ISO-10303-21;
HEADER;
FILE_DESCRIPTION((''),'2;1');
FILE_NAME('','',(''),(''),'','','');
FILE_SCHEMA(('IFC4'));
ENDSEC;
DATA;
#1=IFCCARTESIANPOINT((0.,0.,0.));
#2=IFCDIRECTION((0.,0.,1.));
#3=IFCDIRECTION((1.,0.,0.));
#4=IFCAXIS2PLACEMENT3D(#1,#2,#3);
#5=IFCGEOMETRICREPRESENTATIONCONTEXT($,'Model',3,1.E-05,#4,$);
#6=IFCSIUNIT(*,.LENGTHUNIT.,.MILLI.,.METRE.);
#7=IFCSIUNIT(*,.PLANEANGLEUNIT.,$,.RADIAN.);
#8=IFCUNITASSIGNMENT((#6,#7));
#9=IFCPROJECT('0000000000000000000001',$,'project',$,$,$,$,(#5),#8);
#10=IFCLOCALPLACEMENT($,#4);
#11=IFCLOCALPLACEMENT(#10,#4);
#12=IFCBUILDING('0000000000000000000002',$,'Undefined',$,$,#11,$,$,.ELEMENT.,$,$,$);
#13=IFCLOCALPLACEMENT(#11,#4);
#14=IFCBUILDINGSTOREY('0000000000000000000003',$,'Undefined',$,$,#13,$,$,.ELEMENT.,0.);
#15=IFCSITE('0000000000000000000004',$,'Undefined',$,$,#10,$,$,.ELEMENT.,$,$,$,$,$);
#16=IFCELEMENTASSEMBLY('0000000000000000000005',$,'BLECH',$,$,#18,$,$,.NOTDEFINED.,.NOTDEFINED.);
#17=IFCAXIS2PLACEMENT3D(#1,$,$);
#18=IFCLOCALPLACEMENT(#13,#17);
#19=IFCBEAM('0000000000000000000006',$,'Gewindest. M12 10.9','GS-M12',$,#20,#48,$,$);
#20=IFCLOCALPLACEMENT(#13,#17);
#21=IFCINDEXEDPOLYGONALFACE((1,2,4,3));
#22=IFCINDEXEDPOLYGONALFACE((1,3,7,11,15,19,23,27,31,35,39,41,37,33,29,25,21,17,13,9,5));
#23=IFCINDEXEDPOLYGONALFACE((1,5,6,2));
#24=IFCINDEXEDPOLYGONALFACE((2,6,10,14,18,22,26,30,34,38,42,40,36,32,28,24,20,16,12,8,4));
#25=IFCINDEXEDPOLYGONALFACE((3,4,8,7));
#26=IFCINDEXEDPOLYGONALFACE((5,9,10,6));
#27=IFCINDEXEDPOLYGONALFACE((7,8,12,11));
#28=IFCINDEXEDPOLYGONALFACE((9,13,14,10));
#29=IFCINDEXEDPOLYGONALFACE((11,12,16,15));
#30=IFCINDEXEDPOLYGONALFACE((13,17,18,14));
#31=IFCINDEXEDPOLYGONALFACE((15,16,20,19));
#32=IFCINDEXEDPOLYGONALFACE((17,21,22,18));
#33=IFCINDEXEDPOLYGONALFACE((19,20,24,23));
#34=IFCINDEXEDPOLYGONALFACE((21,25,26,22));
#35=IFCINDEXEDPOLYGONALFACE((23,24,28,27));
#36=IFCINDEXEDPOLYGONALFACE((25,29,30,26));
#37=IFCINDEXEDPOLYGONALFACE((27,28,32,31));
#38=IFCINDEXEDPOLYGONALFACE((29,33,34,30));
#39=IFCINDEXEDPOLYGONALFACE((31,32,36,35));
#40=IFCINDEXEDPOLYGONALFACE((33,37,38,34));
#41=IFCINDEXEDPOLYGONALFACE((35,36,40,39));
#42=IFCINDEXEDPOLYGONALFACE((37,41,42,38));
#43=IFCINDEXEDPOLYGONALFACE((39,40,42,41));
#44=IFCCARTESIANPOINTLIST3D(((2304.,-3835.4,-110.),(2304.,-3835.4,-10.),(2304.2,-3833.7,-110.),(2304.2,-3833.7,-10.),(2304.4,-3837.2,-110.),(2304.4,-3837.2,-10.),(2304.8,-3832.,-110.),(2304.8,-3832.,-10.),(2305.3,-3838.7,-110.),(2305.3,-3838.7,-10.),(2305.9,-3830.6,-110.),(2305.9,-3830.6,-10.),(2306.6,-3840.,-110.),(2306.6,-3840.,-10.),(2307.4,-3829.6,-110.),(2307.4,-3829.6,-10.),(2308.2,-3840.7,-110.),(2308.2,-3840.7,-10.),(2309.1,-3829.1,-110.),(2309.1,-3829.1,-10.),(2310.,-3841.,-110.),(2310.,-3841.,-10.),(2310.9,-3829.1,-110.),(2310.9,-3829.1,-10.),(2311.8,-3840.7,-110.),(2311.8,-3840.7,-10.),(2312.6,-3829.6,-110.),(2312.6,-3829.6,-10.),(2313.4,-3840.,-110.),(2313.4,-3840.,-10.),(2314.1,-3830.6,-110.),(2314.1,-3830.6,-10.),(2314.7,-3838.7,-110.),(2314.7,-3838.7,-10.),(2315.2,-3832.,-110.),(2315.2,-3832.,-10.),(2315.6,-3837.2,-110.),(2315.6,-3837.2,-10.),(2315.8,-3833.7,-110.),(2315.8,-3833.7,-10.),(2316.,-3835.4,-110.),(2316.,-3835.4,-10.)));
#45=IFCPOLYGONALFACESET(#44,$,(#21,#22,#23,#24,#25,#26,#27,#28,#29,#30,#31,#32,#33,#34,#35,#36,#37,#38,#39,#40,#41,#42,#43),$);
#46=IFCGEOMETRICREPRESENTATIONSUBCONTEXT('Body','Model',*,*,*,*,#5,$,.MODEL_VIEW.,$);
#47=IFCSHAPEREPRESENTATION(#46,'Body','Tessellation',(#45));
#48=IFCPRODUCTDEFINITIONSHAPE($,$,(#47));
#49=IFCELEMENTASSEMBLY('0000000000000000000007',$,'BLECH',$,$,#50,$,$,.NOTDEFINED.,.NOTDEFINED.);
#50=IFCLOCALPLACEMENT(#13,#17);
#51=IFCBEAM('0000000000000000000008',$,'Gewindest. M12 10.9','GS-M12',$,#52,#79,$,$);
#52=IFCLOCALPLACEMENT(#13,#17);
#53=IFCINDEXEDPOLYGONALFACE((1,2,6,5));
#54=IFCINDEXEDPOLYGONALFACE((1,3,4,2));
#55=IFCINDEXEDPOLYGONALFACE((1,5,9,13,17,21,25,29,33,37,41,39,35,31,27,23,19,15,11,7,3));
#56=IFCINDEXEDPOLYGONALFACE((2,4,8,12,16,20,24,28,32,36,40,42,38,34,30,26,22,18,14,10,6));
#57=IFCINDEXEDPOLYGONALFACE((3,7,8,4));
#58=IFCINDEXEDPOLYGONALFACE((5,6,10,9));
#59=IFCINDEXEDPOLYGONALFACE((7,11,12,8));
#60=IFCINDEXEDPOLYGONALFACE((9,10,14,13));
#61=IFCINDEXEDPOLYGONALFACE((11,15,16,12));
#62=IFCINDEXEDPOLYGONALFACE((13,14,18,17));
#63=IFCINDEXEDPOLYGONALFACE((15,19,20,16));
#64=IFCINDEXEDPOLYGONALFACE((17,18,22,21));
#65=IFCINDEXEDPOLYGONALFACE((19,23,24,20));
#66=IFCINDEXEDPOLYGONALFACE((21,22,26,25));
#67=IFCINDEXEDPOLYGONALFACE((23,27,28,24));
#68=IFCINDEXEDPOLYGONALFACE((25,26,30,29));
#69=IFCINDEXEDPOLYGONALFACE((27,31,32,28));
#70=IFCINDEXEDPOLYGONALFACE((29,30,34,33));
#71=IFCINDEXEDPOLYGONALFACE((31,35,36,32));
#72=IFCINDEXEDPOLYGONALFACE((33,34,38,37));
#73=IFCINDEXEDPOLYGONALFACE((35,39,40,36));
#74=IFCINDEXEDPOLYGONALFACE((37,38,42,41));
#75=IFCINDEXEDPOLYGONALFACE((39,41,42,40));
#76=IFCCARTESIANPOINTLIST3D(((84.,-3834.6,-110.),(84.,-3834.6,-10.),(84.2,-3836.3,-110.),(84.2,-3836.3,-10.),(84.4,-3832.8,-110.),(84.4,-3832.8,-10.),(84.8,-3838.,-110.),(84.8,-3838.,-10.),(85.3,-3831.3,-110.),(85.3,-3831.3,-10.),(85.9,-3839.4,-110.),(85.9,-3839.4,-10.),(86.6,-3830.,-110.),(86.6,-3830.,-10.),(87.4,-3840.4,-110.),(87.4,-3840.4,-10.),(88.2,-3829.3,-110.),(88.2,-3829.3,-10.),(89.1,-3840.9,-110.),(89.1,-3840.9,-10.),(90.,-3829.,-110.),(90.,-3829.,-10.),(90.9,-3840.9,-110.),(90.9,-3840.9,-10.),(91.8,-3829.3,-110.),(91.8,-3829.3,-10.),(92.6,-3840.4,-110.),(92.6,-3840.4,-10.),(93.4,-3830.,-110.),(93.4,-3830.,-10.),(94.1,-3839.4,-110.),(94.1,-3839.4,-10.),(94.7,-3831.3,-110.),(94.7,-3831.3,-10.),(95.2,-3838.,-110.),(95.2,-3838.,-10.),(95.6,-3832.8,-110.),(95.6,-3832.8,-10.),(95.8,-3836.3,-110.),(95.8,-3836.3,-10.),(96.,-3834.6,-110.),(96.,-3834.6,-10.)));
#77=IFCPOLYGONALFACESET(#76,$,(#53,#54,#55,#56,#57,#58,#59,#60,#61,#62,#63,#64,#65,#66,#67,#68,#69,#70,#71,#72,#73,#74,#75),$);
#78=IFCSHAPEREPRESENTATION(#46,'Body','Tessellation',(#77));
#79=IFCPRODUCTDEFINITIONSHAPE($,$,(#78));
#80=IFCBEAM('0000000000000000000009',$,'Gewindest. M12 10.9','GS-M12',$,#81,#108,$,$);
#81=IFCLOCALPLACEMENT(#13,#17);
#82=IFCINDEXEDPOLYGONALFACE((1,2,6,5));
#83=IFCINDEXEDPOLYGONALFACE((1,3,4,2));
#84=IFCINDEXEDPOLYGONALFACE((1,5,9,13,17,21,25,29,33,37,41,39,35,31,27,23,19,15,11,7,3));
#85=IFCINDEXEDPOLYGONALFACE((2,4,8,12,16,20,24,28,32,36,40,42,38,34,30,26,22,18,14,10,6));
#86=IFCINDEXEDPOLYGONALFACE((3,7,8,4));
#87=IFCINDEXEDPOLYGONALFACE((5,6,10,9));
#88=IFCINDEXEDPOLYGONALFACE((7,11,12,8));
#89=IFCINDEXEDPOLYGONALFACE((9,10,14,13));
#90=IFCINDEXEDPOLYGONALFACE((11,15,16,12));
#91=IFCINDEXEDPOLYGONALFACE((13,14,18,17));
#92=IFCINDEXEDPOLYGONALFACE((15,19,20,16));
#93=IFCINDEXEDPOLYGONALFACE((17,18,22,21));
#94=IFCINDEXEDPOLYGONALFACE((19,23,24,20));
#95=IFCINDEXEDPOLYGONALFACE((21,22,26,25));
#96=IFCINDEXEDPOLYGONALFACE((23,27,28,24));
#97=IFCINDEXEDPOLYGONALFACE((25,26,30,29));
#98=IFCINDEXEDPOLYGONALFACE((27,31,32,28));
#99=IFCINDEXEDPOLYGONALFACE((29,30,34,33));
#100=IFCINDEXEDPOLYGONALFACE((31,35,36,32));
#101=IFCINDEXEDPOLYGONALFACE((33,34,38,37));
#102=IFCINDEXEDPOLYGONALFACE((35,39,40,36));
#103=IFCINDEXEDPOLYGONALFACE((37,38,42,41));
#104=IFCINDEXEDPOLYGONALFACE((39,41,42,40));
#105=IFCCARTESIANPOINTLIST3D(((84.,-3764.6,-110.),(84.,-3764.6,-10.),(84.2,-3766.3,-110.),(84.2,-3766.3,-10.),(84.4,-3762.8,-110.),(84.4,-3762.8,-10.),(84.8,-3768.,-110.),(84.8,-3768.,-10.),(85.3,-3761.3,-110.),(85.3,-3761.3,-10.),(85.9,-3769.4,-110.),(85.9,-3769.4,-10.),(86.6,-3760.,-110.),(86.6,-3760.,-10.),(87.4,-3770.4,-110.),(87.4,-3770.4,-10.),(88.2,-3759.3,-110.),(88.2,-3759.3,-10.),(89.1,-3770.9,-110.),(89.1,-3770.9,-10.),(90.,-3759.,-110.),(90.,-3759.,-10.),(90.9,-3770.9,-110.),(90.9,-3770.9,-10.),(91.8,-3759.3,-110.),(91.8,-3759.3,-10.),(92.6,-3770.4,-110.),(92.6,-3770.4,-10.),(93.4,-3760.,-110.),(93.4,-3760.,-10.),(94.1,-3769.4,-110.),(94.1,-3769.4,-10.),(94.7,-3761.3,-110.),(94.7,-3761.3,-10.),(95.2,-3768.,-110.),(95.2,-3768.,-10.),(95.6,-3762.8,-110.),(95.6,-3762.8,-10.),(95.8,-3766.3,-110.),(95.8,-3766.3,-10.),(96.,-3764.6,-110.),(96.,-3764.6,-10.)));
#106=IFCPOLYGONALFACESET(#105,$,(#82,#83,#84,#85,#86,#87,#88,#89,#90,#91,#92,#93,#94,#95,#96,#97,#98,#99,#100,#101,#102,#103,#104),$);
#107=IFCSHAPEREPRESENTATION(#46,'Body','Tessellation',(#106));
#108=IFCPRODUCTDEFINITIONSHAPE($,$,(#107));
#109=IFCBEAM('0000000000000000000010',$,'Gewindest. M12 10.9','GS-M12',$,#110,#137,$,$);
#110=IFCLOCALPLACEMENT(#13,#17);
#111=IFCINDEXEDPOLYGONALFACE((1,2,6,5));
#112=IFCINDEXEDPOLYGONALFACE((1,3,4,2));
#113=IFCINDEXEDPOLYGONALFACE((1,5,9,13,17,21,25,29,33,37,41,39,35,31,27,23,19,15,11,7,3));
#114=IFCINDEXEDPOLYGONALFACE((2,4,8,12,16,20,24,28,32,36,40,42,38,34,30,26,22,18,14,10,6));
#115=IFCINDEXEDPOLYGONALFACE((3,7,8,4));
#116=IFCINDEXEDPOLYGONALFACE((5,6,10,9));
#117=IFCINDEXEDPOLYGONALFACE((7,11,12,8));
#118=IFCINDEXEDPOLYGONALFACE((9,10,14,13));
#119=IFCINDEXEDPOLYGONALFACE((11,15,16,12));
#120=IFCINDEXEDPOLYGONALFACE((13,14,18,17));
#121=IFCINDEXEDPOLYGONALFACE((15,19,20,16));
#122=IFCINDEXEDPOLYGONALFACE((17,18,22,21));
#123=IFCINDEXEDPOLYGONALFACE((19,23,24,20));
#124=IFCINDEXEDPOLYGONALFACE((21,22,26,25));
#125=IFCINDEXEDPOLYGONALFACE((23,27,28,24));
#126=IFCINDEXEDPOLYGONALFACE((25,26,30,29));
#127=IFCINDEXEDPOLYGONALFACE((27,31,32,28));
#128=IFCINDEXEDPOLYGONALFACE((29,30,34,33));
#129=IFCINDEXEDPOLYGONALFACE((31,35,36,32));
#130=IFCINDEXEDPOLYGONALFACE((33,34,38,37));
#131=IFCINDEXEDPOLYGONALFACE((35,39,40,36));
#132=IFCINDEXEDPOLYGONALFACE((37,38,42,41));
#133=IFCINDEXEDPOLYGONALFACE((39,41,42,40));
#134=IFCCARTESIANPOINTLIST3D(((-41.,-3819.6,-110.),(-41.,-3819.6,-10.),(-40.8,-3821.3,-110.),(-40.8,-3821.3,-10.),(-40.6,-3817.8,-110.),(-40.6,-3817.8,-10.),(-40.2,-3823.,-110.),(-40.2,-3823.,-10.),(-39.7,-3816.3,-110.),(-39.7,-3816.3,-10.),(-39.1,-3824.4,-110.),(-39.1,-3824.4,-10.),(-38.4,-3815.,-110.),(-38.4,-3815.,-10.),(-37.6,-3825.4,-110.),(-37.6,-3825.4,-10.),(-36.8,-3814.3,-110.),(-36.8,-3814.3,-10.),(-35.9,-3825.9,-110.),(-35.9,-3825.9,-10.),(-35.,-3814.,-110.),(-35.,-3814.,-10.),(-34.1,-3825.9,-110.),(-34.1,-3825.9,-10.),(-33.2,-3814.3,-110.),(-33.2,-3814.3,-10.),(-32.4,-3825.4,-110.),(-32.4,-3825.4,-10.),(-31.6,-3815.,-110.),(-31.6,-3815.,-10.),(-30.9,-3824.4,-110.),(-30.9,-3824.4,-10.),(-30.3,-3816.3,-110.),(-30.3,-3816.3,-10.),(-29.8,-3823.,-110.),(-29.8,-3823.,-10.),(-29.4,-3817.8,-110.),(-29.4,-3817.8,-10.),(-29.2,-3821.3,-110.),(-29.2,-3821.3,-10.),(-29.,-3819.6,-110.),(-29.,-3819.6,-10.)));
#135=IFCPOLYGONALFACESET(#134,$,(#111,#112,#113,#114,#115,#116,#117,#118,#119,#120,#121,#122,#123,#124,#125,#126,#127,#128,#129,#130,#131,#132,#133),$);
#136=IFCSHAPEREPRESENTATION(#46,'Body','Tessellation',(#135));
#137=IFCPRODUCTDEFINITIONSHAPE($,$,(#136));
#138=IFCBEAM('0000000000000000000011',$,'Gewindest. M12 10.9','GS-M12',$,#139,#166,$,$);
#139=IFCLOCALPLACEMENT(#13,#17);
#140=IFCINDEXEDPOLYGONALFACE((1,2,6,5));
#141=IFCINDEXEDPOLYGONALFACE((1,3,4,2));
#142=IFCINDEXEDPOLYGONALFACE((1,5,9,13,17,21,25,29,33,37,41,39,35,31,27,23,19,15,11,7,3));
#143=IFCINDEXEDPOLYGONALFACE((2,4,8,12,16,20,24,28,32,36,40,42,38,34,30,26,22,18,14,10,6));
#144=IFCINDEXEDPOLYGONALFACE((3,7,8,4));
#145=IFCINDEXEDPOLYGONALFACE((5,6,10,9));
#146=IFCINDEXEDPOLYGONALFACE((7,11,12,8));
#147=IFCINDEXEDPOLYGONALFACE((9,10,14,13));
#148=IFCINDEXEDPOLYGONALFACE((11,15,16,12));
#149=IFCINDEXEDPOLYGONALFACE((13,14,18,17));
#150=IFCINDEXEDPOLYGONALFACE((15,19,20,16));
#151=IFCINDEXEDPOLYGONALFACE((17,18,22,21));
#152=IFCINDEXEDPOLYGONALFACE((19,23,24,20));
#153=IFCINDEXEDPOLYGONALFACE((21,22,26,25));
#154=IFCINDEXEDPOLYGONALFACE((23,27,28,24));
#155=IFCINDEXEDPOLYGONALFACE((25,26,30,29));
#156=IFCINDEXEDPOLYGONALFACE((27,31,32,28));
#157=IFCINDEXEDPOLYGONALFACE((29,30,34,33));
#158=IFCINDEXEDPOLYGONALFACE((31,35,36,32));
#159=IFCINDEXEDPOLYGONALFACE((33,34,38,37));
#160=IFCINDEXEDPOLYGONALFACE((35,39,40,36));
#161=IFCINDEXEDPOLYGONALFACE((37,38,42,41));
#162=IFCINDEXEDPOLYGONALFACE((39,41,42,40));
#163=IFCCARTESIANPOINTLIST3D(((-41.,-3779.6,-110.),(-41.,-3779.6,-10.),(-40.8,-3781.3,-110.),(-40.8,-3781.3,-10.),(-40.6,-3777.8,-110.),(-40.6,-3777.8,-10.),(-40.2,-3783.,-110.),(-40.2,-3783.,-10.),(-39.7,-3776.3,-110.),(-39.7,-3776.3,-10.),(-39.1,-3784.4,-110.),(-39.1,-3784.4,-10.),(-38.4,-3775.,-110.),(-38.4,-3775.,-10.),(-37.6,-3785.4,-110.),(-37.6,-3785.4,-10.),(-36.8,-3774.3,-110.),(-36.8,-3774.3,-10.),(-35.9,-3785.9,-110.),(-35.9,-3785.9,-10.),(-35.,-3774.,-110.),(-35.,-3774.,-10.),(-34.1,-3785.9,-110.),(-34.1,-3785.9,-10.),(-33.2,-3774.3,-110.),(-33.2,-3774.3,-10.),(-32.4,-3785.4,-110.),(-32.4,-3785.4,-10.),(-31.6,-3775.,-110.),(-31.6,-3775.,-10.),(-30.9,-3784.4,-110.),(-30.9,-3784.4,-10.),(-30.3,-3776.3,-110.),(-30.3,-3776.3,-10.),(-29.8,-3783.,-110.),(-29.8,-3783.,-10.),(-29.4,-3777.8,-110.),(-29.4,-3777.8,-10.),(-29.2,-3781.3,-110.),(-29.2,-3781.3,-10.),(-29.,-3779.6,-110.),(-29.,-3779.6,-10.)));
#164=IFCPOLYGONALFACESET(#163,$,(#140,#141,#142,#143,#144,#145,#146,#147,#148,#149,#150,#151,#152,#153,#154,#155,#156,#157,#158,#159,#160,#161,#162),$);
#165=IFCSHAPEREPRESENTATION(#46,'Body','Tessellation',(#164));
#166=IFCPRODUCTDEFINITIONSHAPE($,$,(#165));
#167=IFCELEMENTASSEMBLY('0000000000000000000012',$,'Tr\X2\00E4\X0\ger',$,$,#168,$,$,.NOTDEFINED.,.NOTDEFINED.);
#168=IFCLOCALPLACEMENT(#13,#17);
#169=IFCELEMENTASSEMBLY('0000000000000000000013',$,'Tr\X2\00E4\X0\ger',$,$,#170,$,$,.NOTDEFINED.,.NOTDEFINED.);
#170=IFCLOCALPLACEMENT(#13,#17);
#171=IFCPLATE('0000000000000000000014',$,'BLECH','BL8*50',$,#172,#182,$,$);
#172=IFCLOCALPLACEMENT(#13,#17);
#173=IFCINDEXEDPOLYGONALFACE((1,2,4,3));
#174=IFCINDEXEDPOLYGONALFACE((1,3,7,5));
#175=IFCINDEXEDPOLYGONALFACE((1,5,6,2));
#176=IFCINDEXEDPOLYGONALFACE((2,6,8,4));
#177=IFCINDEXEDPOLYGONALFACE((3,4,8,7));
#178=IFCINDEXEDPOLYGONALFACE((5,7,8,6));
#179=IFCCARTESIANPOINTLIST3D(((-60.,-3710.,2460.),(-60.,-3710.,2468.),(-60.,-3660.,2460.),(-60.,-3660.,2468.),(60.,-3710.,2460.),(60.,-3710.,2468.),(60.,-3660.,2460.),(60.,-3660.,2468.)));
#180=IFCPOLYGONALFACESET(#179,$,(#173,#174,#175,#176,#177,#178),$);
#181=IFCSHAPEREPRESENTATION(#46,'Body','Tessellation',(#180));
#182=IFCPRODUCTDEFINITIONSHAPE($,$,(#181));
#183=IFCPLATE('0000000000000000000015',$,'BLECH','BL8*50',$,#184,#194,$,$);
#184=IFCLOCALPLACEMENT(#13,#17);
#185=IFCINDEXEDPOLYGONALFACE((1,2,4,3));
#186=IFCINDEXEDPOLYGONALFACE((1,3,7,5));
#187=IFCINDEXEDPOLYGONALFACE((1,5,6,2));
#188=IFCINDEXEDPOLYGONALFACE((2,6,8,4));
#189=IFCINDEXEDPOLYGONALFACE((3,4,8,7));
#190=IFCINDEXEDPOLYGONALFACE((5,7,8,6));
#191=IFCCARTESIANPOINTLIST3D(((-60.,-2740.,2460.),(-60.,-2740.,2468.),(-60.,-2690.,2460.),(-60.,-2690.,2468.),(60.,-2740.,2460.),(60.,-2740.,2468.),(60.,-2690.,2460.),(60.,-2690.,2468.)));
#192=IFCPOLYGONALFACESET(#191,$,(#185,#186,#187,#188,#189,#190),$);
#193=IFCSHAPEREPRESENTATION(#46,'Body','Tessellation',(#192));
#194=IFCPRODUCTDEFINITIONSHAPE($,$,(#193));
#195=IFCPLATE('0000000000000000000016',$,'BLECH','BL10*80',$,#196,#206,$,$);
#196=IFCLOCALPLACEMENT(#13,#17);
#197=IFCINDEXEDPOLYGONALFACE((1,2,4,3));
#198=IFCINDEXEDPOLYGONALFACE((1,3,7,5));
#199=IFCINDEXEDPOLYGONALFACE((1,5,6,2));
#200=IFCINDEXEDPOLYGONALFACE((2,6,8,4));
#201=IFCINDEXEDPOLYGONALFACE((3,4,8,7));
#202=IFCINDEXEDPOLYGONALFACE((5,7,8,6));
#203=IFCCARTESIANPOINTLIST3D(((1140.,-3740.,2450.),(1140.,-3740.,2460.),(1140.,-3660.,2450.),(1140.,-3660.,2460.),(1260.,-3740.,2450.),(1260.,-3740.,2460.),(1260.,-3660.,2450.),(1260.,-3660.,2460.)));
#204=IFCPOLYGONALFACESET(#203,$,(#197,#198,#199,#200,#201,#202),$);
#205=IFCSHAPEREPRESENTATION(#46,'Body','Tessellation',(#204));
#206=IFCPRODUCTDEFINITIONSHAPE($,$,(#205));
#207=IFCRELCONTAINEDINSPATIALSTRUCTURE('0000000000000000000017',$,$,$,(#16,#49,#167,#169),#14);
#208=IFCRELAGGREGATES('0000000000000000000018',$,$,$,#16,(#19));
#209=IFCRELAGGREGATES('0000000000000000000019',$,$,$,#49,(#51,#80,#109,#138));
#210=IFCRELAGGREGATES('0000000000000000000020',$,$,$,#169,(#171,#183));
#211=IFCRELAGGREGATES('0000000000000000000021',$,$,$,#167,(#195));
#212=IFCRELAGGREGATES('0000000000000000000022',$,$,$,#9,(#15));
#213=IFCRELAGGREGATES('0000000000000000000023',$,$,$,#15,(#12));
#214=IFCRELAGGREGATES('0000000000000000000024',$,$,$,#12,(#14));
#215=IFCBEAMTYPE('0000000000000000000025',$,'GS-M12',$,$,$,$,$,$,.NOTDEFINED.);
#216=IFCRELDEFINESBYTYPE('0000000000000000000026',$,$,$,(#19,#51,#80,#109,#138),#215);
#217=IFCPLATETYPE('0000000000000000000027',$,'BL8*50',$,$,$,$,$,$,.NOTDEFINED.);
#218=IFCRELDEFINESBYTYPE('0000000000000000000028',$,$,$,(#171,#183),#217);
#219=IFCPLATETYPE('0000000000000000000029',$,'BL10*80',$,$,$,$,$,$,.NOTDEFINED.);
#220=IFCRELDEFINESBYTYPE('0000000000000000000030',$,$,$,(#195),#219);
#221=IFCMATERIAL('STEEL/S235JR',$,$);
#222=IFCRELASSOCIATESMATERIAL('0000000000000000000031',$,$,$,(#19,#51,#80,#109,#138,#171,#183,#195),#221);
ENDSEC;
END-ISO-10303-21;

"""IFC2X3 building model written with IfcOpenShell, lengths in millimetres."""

from ifc_helpers import new_model, si_unit, frame, origin_with_axes, origin_2d_with_axis, place, context, subcontext, project, spatial, polyline, circle, outline, extrude, material, type_object, element, aggregate, save


model = new_model("IFC2X3")

# Units and contexts
model_context = context("Model", 3, precision=1e-05, world=origin_with_axes())
body_context = subcontext(model_context, "Body", "Model", "MODEL_VIEW")
ifc_project = project(units=[si_unit("LENGTHUNIT", "METRE", prefix="MILLI"), si_unit("PLANEANGLEUNIT", "RADIAN")], contexts=[model_context])

# Site, building, storey
site_placement = place(None, origin_with_axes())
site = spatial("IfcSite", under=ifc_project, at=site_placement, Name="Undefined", CompositionType="ELEMENT")
building_placement = place(site_placement, origin_with_axes())
building = spatial("IfcBuilding", under=site, at=building_placement, Name="Undefined", CompositionType="ELEMENT")
storey_placement = place(building_placement, origin_with_axes())
storey = spatial("IfcBuildingStorey", under=building, at=storey_placement, Name="Undefined", CompositionType="ELEMENT", Elevation=0.0)

# Element assembly, beam
assembly_1_placement = place(storey_placement, origin_with_axes())
assembly_1 = element("IfcElementAssembly", 1, at=assembly_1_placement, inside=storey, Name="BLECH", AssemblyPlace="NOTDEFINED", PredefinedType="NOTDEFINED")
ifc_material_1 = material(Name="STEEL/S235JR")
beam_type_1 = type_object("IfcBeamType", Name="GS-M12", PredefinedType="NOTDEFINED")
beam_1_placement = place(assembly_1_placement, frame((2310.0, -3835.0, -10.0), z_axis=(1.0, 0.0, 0.0), x_axis=(0.0, 0.0, -1.0)))
beam_1 = element("IfcBeam", 2, at=beam_1_placement, type_object=beam_type_1, material=ifc_material_1, Name="Gewindest. M12 10.9", Description="GS-M12", context=body_context, shape_type="SweptSolid", body=[
    extrude(circle(Radius=6.0, at=origin_2d_with_axis()), frame((100.0, 0.0, 0.0), z_axis=(-1.0, 0.0, 0.0), x_axis=(0.0, -1.0, 0.0)), (0.0, 0.0, 1.0), 100.0),
])
aggregate(assembly_1, [beam_1])

# Element assembly, beams
assembly_2_placement = place(storey_placement, origin_with_axes())
assembly_2 = element("IfcElementAssembly", 3, at=assembly_2_placement, inside=storey, Name="BLECH", AssemblyPlace="NOTDEFINED", PredefinedType="NOTDEFINED")
beam_2_placement = place(assembly_2_placement, frame((90.0, -3835.0, -10.0), z_axis=(-1.0, 0.0, 0.0), x_axis=(0.0, 0.0, -1.0)))
beam_2 = element("IfcBeam", 4, at=beam_2_placement, type_object=beam_type_1, material=ifc_material_1, Name="Gewindest. M12 10.9", Description="GS-M12", context=body_context, shape_type="SweptSolid", body=[
    extrude(circle(Radius=6.0, at=origin_2d_with_axis()), frame((100.0, 0.0, 0.0), z_axis=(-1.0, 0.0, 0.0), x_axis=(0.0, -1.0, 0.0)), (0.0, 0.0, 1.0), 100.0),
])
beam_3_placement = place(assembly_2_placement, frame((90.0, -3765.0, -10.0), z_axis=(-1.0, 0.0, 0.0), x_axis=(0.0, 0.0, -1.0)))
beam_3 = element("IfcBeam", 5, at=beam_3_placement, type_object=beam_type_1, material=ifc_material_1, Name="Gewindest. M12 10.9", Description="GS-M12", context=body_context, shape_type="SweptSolid", body=[
    extrude(circle(Radius=6.0, at=origin_2d_with_axis()), frame((100.0, 0.0, 0.0), z_axis=(-1.0, 0.0, 0.0), x_axis=(0.0, -1.0, 0.0)), (0.0, 0.0, 1.0), 100.0),
])
beam_4_placement = place(assembly_2_placement, frame((-35.0, -3820.0, -10.0), z_axis=(-1.0, 0.0, 0.0), x_axis=(0.0, 0.0, -1.0)))
beam_4 = element("IfcBeam", 6, at=beam_4_placement, type_object=beam_type_1, material=ifc_material_1, Name="Gewindest. M12 10.9", Description="GS-M12", context=body_context, shape_type="SweptSolid", body=[
    extrude(circle(Radius=6.0, at=origin_2d_with_axis()), frame((100.0, 0.0, 0.0), z_axis=(-1.0, 0.0, 0.0), x_axis=(0.0, -1.0, 0.0)), (0.0, 0.0, 1.0), 100.0),
])
beam_5_placement = place(assembly_2_placement, frame((-35.0, -3780.0, -10.0), z_axis=(-1.0, 0.0, 0.0), x_axis=(0.0, 0.0, -1.0)))
beam_5 = element("IfcBeam", 7, at=beam_5_placement, type_object=beam_type_1, material=ifc_material_1, Name="Gewindest. M12 10.9", Description="GS-M12", context=body_context, shape_type="SweptSolid", body=[
    extrude(circle(Radius=6.0, at=origin_2d_with_axis()), frame((100.0, 0.0, 0.0), z_axis=(-1.0, 0.0, 0.0), x_axis=(0.0, -1.0, 0.0)), (0.0, 0.0, 1.0), 100.0),
])
aggregate(assembly_2, [beam_2, beam_3, beam_4, beam_5])

# Element assembly
assembly_3_placement = place(storey_placement, origin_with_axes())
assembly_3 = element("IfcElementAssembly", 8, at=assembly_3_placement, inside=storey, Name="Träger", AssemblyPlace="NOTDEFINED", PredefinedType="NOTDEFINED")

# Element assembly, plates
assembly_4_placement = place(storey_placement, origin_with_axes())
assembly_4 = element("IfcElementAssembly", 9, at=assembly_4_placement, inside=storey, Name="Träger", AssemblyPlace="NOTDEFINED", PredefinedType="NOTDEFINED")
plate_type_1 = type_object("IfcPlateType", Name="BL8*50", PredefinedType="NOTDEFINED")
plate_1_placement = place(assembly_4_placement, frame((-60.0, -3660.0, 2464.0), z_axis=(0.0, 0.0, -1.0), x_axis=(1.0, 0.0, 0.0)))
plate_1 = element("IfcPlate", 10, at=plate_1_placement, type_object=plate_type_1, material=ifc_material_1, Name="BLECH", Description="BL8*50", context=body_context, shape_type="SweptSolid", body=[
    extrude(outline(polyline([(0.0, 0.0), (120.0, 0.0), (120.0, 50.0), (0.0, 50.0), (0.0, 0.0)])), frame((0.0, 0.0, -4.0), z_axis=(0.0, 0.0, 1.0), x_axis=(1.0, 0.0, 0.0)), (0.0, 0.0, 1.0), 8.0),
])
plate_2_placement = place(assembly_4_placement, frame((-60.0, -2740.0, 2464.0), z_axis=(0.0, 0.0, 1.0), x_axis=(1.0, 0.0, 0.0)))
plate_2 = element("IfcPlate", 11, at=plate_2_placement, type_object=plate_type_1, material=ifc_material_1, Name="BLECH", Description="BL8*50", context=body_context, shape_type="SweptSolid", body=[
    extrude(outline(polyline([(0.0, 0.0), (120.0, 0.0), (120.0, 50.0), (0.0, 50.0), (0.0, 0.0)])), frame((0.0, 0.0, -4.0), z_axis=(0.0, 0.0, 1.0), x_axis=(1.0, 0.0, 0.0)), (0.0, 0.0, 1.0), 8.0),
])
aggregate(assembly_4, [plate_1, plate_2])

# Plate
plate_type_2 = type_object("IfcPlateType", Name="BL10*80", PredefinedType="NOTDEFINED")
plate_3_placement = place(assembly_3_placement, frame((1140.0, -3660.0, 2455.0), z_axis=(0.0, 0.0, -1.0), x_axis=(1.0, 0.0, 0.0)))
plate_3 = element("IfcPlate", 12, at=plate_3_placement, type_object=plate_type_2, material=ifc_material_1, Name="BLECH", Description="BL10*80", context=body_context, shape_type="SweptSolid", body=[
    extrude(outline(polyline([(0.0, 0.0), (120.0, 0.0), (120.0, 80.0), (0.0, 80.0), (0.0, 0.0)])), frame((0.0, 0.0, -5.0), z_axis=(0.0, 0.0, 1.0), x_axis=(1.0, 0.0, 0.0)), (0.0, 0.0, 1.0), 10.0),
])

aggregate(assembly_3, [plate_3])

save(model, "model.ifc")
